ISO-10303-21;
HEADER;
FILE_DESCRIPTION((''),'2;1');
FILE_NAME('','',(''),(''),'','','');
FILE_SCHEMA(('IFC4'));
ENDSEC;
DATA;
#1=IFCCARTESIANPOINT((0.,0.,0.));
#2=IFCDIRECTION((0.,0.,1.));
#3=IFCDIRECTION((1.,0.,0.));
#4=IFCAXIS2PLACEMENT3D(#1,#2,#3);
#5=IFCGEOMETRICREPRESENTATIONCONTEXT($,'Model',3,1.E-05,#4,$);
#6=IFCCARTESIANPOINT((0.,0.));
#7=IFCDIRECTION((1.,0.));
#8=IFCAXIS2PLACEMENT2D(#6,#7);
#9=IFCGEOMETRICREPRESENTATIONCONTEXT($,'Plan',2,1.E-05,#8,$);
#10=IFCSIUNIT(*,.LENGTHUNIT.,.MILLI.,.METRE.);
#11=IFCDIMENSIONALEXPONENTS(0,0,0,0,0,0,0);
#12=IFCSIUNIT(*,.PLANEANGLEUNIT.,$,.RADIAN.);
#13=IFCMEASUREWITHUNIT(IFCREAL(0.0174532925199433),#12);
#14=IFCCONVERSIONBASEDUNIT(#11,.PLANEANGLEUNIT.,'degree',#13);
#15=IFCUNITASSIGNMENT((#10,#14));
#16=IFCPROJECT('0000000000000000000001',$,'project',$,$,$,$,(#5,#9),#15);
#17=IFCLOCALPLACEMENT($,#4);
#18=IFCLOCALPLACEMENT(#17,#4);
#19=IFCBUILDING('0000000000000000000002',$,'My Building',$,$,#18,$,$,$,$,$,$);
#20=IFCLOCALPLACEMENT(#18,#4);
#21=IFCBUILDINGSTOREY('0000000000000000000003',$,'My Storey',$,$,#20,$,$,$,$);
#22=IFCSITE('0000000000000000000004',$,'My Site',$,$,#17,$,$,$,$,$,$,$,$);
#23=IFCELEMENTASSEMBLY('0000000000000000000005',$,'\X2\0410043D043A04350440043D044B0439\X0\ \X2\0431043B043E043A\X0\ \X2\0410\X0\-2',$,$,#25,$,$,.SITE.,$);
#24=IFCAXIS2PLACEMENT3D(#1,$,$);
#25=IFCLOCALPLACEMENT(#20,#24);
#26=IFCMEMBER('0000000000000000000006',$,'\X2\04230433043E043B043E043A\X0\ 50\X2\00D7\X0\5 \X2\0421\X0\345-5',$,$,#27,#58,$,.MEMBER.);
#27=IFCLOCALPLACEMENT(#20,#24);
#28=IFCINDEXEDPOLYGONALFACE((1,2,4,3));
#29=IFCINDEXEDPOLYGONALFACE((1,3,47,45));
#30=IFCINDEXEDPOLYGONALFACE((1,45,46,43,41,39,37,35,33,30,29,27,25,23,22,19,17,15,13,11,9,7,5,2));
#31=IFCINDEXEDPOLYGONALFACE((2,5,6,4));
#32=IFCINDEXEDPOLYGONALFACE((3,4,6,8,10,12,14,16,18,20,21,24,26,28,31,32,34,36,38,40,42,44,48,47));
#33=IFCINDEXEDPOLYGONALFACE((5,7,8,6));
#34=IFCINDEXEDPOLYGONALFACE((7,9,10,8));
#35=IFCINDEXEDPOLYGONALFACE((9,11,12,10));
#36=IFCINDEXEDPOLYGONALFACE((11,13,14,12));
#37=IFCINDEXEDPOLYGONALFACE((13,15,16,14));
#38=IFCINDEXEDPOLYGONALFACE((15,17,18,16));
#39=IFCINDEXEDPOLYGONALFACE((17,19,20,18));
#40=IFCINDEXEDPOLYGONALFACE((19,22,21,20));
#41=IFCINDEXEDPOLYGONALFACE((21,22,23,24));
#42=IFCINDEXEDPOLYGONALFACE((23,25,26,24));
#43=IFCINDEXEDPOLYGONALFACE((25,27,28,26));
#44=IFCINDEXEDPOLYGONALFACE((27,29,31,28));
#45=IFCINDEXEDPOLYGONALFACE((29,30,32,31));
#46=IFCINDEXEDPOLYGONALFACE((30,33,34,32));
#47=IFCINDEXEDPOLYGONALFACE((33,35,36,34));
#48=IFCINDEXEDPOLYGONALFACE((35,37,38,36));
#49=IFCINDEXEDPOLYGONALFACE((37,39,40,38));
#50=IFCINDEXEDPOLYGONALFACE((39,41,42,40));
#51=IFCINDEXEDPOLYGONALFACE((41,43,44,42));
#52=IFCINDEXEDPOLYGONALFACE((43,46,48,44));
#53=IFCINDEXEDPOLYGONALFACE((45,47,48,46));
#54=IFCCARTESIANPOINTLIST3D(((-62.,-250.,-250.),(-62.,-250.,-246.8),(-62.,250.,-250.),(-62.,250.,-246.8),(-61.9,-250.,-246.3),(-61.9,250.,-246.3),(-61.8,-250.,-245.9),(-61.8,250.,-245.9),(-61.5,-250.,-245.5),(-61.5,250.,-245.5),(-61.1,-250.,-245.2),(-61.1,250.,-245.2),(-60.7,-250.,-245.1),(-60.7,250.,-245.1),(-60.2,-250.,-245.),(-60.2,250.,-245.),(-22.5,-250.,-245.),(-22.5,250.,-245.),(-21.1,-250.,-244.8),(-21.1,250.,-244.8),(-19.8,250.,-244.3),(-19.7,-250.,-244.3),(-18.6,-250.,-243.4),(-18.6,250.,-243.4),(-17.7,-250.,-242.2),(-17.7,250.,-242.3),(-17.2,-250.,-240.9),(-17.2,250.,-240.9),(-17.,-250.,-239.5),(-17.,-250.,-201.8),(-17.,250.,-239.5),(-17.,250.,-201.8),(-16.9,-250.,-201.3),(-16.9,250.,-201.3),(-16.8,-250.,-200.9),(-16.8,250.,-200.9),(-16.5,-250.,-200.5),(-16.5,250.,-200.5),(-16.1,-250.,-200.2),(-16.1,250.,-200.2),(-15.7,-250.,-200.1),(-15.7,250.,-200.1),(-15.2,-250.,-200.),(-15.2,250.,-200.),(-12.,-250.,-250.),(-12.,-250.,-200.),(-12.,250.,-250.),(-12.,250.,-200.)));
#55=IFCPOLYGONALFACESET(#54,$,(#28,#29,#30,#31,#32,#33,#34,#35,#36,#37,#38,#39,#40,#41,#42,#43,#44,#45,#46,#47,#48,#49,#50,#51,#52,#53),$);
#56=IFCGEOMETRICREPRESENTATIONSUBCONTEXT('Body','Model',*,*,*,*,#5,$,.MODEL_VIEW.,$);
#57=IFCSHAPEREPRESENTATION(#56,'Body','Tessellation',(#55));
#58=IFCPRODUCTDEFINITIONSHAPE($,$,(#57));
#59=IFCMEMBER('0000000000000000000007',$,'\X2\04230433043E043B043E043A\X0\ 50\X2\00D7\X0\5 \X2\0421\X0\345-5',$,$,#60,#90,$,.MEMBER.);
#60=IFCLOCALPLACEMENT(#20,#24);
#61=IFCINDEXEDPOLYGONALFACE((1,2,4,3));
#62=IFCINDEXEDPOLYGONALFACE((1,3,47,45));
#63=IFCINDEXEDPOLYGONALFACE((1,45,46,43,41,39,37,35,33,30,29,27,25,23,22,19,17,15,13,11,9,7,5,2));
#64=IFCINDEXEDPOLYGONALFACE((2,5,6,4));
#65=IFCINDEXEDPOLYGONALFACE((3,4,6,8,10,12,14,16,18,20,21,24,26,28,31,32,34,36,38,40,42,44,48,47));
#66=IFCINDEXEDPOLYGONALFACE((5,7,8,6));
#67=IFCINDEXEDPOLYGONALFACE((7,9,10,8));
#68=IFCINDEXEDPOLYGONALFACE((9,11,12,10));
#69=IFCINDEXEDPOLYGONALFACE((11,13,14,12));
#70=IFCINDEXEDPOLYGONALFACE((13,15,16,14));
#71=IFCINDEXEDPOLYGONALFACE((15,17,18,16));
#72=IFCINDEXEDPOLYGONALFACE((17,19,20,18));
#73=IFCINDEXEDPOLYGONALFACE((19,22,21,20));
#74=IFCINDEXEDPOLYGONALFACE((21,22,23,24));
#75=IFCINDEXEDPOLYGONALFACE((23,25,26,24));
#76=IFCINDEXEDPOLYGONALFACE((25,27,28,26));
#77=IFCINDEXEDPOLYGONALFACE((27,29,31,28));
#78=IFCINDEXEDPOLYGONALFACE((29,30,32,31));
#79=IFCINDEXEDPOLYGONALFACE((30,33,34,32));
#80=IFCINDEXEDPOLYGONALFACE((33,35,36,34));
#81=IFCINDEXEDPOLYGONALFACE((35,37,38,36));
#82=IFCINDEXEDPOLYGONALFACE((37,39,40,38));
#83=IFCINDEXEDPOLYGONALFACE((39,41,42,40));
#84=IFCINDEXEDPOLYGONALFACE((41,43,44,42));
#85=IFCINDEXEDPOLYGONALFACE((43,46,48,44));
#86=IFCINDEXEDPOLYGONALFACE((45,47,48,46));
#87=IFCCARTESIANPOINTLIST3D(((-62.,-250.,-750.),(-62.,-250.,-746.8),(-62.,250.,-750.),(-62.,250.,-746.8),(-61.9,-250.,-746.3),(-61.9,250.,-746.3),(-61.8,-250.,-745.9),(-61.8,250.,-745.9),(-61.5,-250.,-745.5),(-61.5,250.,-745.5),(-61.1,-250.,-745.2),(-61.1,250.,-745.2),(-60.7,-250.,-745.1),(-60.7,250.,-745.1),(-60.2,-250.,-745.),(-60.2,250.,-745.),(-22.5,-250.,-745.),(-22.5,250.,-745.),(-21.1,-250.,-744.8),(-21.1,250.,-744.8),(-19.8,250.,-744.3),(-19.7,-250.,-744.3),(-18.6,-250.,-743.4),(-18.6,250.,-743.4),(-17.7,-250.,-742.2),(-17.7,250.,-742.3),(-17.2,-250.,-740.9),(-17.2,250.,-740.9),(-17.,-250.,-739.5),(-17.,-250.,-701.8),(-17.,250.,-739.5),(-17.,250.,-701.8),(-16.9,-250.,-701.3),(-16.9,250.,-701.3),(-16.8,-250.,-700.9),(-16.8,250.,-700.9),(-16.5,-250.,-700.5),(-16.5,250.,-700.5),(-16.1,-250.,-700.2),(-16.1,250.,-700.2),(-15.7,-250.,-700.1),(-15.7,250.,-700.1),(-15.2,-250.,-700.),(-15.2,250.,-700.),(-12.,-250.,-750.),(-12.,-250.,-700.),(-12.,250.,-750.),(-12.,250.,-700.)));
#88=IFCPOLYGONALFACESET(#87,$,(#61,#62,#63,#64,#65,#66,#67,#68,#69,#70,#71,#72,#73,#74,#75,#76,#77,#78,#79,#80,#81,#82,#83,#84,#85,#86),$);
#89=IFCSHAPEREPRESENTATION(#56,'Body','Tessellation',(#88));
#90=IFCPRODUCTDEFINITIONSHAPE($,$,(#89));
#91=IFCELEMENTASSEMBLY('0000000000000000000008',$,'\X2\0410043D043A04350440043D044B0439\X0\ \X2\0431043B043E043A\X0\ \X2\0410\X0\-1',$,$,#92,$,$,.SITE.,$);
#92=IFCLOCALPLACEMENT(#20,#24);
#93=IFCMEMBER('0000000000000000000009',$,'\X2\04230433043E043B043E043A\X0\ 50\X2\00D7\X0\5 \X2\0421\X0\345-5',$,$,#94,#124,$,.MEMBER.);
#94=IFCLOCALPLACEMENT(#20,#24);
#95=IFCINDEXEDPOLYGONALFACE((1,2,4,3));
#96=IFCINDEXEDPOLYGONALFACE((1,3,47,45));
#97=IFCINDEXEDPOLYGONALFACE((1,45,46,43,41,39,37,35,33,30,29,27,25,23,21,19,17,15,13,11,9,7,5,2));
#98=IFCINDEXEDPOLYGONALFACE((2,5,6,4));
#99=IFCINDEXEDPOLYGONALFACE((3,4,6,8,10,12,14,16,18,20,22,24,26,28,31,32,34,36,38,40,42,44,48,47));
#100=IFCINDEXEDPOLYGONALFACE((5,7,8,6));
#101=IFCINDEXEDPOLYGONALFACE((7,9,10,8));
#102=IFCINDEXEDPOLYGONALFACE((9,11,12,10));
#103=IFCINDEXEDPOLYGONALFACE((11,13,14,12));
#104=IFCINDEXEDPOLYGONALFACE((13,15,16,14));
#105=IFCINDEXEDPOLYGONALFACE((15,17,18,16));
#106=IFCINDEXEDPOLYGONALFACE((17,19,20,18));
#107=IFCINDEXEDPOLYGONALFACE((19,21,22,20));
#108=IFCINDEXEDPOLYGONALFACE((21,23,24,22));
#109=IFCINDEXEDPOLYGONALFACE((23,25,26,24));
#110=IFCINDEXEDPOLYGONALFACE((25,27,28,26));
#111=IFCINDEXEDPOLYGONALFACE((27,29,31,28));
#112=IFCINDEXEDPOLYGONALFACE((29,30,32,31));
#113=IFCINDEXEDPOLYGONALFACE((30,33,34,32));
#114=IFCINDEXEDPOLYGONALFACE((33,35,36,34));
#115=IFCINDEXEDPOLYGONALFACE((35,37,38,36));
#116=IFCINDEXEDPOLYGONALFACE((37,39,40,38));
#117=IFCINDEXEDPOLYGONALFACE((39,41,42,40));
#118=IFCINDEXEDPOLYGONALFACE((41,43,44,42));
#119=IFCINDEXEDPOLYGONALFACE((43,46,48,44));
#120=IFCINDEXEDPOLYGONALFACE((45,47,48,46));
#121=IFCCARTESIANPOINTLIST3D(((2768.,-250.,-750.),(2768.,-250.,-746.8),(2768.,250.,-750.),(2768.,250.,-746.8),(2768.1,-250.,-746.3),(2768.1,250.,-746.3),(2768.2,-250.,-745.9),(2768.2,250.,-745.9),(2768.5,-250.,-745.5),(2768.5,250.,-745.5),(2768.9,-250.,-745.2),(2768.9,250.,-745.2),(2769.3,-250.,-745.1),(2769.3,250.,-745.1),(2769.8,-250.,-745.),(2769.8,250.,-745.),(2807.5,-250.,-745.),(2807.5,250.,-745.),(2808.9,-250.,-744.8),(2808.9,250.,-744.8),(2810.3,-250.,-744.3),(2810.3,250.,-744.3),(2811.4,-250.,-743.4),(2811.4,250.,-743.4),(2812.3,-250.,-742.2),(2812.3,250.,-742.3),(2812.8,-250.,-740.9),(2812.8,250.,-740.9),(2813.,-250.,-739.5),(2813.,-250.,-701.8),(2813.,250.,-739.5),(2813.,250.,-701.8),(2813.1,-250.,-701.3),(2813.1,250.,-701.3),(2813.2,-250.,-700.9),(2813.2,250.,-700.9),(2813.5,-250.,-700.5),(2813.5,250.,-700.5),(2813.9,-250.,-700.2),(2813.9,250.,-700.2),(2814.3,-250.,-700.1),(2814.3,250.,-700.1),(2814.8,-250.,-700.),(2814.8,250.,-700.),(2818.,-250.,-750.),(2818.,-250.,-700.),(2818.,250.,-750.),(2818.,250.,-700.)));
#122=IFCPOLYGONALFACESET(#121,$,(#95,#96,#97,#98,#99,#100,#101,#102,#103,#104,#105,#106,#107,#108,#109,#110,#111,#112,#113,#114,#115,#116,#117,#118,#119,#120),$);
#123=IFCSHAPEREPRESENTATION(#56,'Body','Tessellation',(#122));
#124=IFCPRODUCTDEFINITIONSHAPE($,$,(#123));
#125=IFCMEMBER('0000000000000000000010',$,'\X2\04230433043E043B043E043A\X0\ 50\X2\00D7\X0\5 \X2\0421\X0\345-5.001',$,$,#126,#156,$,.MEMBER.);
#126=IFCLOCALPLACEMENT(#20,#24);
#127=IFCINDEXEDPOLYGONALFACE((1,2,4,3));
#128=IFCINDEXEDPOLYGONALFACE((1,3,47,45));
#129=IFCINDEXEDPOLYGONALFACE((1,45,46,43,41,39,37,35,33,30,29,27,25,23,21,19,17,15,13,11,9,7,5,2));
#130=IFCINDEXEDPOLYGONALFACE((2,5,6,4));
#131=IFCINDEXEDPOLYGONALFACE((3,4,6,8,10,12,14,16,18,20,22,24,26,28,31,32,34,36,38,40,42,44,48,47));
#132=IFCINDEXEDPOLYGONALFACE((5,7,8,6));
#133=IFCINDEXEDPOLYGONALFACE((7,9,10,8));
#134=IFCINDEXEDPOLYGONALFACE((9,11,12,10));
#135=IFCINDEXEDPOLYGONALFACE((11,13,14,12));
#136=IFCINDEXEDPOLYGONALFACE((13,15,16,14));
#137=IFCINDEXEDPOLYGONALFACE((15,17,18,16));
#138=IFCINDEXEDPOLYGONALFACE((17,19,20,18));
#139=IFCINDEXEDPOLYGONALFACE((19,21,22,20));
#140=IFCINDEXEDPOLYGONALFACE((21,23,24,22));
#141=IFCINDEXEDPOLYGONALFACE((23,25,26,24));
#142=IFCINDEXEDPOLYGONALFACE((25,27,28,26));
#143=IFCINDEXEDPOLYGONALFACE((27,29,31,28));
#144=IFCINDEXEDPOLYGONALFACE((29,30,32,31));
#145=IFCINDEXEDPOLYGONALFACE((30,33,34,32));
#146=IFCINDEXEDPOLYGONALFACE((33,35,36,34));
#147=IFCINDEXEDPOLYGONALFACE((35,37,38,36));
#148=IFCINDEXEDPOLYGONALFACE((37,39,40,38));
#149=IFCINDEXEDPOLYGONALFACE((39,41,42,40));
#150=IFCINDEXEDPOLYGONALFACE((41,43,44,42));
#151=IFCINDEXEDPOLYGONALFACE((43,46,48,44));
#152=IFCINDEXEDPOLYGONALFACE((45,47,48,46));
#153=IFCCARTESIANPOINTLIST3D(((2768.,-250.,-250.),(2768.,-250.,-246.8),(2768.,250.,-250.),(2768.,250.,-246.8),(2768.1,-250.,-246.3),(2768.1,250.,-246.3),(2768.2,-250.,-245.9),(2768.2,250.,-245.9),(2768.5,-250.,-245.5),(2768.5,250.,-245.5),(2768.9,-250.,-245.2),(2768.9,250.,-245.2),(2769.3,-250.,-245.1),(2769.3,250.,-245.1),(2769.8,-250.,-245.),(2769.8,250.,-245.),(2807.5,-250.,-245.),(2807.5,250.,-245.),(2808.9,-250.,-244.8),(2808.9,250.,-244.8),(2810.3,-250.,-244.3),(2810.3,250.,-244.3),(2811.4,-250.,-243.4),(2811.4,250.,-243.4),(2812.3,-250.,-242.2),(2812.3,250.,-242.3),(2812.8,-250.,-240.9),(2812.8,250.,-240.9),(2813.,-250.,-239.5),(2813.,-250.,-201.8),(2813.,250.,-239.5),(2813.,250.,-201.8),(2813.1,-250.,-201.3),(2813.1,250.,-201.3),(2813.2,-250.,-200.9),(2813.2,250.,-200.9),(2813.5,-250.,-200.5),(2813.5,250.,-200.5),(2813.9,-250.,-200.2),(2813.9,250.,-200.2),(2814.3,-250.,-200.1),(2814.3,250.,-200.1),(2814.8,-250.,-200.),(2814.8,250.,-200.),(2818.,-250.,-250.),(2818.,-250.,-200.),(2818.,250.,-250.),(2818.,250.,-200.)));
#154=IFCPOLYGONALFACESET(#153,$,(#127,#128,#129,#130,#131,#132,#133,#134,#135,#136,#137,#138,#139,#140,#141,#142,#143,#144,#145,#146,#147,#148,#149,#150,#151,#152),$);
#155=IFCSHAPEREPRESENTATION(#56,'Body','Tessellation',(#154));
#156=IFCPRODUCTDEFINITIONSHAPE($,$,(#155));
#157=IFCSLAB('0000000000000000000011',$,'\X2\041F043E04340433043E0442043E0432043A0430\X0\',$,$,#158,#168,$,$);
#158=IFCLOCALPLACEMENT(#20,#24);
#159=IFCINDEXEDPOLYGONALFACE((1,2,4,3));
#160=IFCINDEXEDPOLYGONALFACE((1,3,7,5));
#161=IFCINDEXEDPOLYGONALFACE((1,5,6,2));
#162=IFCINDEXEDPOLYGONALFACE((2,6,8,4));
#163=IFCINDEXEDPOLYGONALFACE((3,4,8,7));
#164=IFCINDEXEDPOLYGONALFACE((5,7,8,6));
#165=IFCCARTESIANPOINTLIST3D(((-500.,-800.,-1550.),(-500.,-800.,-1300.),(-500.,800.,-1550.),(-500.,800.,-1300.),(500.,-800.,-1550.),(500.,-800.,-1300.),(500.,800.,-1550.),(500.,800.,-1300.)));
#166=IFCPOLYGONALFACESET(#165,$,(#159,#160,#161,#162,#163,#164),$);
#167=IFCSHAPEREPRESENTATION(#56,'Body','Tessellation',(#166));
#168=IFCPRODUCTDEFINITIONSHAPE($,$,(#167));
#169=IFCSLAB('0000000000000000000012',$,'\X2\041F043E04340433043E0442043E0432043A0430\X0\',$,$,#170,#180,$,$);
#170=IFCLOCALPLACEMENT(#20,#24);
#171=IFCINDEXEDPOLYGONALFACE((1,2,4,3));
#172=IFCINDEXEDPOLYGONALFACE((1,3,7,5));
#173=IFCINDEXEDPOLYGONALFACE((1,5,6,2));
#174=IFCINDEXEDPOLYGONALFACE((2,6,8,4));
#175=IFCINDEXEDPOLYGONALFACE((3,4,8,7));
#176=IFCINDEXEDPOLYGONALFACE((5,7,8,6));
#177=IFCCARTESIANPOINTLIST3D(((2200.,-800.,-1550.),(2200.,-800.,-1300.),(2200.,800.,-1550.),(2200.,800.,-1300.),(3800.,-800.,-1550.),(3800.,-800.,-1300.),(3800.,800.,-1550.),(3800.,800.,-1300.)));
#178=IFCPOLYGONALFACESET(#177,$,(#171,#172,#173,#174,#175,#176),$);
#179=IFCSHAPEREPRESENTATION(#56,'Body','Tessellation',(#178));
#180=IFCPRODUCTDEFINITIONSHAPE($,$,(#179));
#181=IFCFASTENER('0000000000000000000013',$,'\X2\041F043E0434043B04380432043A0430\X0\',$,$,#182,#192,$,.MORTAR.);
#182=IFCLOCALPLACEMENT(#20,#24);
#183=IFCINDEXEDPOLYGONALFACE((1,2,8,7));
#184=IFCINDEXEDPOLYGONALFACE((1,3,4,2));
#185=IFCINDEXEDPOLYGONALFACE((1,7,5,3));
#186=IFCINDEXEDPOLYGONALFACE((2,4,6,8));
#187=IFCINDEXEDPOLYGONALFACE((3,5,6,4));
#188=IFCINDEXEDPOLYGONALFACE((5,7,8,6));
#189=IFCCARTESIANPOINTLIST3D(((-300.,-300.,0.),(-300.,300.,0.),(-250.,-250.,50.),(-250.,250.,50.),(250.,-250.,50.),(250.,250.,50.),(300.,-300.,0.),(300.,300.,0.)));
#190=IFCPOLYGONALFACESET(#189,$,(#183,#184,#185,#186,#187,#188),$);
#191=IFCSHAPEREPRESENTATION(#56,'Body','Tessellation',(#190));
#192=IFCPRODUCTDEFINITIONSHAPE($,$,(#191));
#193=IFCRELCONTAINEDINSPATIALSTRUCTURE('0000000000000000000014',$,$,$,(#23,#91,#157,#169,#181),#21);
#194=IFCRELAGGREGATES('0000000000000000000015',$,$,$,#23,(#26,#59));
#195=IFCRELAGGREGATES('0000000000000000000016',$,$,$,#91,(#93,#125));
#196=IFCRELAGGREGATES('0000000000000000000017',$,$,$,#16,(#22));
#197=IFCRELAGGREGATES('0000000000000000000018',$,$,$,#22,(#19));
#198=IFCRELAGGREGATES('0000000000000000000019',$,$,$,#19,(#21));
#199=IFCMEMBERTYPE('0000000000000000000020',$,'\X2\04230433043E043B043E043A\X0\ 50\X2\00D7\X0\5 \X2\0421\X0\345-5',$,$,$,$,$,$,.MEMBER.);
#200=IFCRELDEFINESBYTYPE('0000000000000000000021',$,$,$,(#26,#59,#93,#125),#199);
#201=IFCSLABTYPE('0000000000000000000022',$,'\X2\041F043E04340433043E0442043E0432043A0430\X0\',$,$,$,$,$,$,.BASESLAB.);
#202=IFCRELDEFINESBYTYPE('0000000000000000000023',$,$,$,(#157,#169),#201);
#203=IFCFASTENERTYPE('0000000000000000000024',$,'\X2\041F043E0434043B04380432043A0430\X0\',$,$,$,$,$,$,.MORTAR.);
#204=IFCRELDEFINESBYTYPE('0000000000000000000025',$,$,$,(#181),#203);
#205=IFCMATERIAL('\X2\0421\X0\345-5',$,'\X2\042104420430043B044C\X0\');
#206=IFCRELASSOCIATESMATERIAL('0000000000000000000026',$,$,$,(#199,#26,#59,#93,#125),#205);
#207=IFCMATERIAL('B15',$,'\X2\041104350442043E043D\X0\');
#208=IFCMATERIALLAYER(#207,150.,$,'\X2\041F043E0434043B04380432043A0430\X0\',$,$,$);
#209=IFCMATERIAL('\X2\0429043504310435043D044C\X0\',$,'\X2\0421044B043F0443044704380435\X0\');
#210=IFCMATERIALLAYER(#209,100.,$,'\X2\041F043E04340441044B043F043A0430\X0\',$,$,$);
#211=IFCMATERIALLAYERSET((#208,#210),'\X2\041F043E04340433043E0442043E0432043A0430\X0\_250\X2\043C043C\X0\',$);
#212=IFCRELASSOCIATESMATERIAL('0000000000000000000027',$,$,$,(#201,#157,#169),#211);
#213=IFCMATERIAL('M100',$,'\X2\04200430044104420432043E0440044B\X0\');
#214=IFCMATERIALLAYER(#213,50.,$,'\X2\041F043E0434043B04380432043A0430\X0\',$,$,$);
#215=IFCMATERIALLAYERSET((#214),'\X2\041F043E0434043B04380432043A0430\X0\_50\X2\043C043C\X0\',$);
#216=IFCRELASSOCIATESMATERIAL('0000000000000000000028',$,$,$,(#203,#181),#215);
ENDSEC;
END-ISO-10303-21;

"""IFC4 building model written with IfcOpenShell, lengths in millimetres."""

from ifc_helpers import new_model, entity, si_unit, converted_unit, frame, origin_with_axes, origin_2d_with_axis, place, context, subcontext, project, spatial, line, indexed_curve, l_section, outline, extrude, clip, halfspace, material, layer, layer_set, layer_usage, material_profile, profile_set, profile_usage, type_object, element, aggregate, save


model = new_model("IFC4")

# Units and contexts
model_context = context("Model", 3, precision=1e-05, world=origin_with_axes())
plan_context = context("Plan", 2, precision=1e-05, world=origin_2d_with_axis())
body_context = subcontext(model_context, "Body", "Model", "MODEL_VIEW")
ifc_project = project(units=[si_unit("LENGTHUNIT", "METRE", prefix="MILLI"), converted_unit("PLANEANGLEUNIT", "degree", entity("IfcReal", 0.0174532925199433), si_unit("PLANEANGLEUNIT", "RADIAN"), dimensions=[0, 0, 0, 0, 0, 0, 0])], contexts=[model_context, plan_context])

# Site, building, storey
site_placement = place(None, origin_with_axes())
site = spatial("IfcSite", under=ifc_project, at=site_placement, Name="My Site")
building_placement = place(site_placement, origin_with_axes())
building = spatial("IfcBuilding", under=site, at=building_placement, Name="My Building")
storey_placement = place(building_placement, origin_with_axes())
storey = spatial("IfcBuildingStorey", under=building, at=storey_placement, Name="My Storey")

# Element assemblies, members
placement_1 = place(storey_placement, origin_with_axes())
assembly_1 = element("IfcElementAssembly", 1, at=placement_1, inside=storey, Name="Анкерный блок А-2", AssemblyPlace="SITE")
ifc_material_1 = material(Name="С345-5", Category="Сталь")
ifc_material_profile = material_profile(ifc_material_1, l_section(Depth=50.0, Width=50.0, Thickness=5.0, FilletRadius=5.5, EdgeRadius=1.8))
ifc_profile_set = profile_set([ifc_material_profile])
ifc_profile_usage_1 = profile_usage(ifc_profile_set, cardinal=3)
member_type = type_object("IfcMemberType", Name="Уголок 50×5 С345-5", PredefinedType="MEMBER", material=ifc_profile_set)
member_1_placement = place(placement_1, frame((-12.0, -250.0, -250.0), z_axis=(0.0, 1.0, 0.0), x_axis=(-1.0, 0.0, 0.0)))
member_1 = element("IfcMember", 2, at=member_1_placement, type_object=member_type, material=ifc_profile_usage_1, Name="Уголок 50×5 С345-5", PredefinedType="MEMBER", context=body_context, shape_type="SweptSolid", body=[
    extrude(l_section(Depth=50.0, Width=50.0, Thickness=5.0, FilletRadius=5.5, EdgeRadius=1.8), frame((25.0, 25.0, 0.0), z_axis=(0.0, 0.0, 1.0), x_axis=(1.0, 0.0, 0.0)), (0.0, 0.0, 1.0), 500.0),
])
ifc_profile_usage_2 = profile_usage(ifc_profile_set, cardinal=3)
member_2_placement = place(placement_1, frame((-12.0, -250.0, -750.0), z_axis=(0.0, 1.0, 0.0), x_axis=(-1.0, 0.0, 0.0)))
member_2 = element("IfcMember", 3, at=member_2_placement, type_object=member_type, material=ifc_profile_usage_2, Name="Уголок 50×5 С345-5", PredefinedType="MEMBER", context=body_context, shape_type="SweptSolid", body=[
    extrude(l_section(Depth=50.0, Width=50.0, Thickness=5.0, FilletRadius=5.5, EdgeRadius=1.8), frame((25.0, 25.0, 0.0), z_axis=(0.0, 0.0, 1.0), x_axis=(1.0, 0.0, 0.0)), (0.0, 0.0, 1.0), 500.0),
])
placement_2 = place(storey_placement, frame((3000.0, 0.0, 0.0), z_axis=(0.0, 0.0, 1.0), x_axis=(1.0, 0.0, 0.0)))
assembly_2 = element("IfcElementAssembly", 4, at=placement_2, inside=storey, Name="Анкерный блок А-1", AssemblyPlace="SITE")
ifc_profile_usage_3 = profile_usage(ifc_profile_set, cardinal=3)
member_3_placement = place(placement_2, frame((-182.0, -250.0, -750.0), z_axis=(0.0, 1.0, 0.0), x_axis=(-1.0, 0.0, 0.0)))
member_3 = element("IfcMember", 5, at=member_3_placement, type_object=member_type, material=ifc_profile_usage_3, Name="Уголок 50×5 С345-5", PredefinedType="MEMBER", context=body_context, shape_type="SweptSolid", body=[
    extrude(l_section(Depth=50.0, Width=50.0, Thickness=5.0, FilletRadius=5.5, EdgeRadius=1.8), frame((25.0, 25.0, 0.0), z_axis=(0.0, 0.0, 1.0), x_axis=(1.0, 0.0, 0.0)), (0.0, 0.0, 1.0), 500.0),
])
ifc_profile_usage_4 = profile_usage(ifc_profile_set, cardinal=3)
member_4_placement = place(placement_2, frame((-182.0, -250.0, -250.0), z_axis=(0.0, 1.0, 0.0), x_axis=(-1.0, 0.0, 0.0)))
member_4 = element("IfcMember", 6, at=member_4_placement, type_object=member_type, material=ifc_profile_usage_4, Name="Уголок 50×5 С345-5.001", PredefinedType="MEMBER", context=body_context, shape_type="SweptSolid", body=[
    extrude(l_section(Depth=50.0, Width=50.0, Thickness=5.0, FilletRadius=5.5, EdgeRadius=1.8), frame((25.0, 25.0, 0.0), z_axis=(0.0, 0.0, 1.0), x_axis=(1.0, 0.0, 0.0)), (0.0, 0.0, 1.0), 500.0),
])

# Slabs
ifc_material_2 = material(Name="B15", Category="Бетон")
ifc_layer_1 = layer(ifc_material_2, 150.0, Name="Подливка")
ifc_material_3 = material(Name="Щебень", Category="Сыпучие")
ifc_layer_2 = layer(ifc_material_3, 100.0, Name="Подсыпка")
ifc_layer_set_1 = layer_set([ifc_layer_1, ifc_layer_2], Name="Подготовка_250мм")
ifc_layer_usage_1 = layer_usage(ifc_layer_set_1, "AXIS3", "NEGATIVE", 0.0)
slab_type = type_object("IfcSlabType", Name="Подготовка", PredefinedType="BASESLAB", material=ifc_layer_set_1)
slab_1_placement = place(storey_placement, frame((0.0, 0.0, -1550.0), z_axis=(0.0, 0.0, 1.0), x_axis=(1.0, 0.0, 0.0)))
element("IfcSlab", 7, at=slab_1_placement, inside=storey, type_object=slab_type, material=ifc_layer_usage_1, Name="Подготовка", context=body_context, shape_type="SweptSolid", body=[
    extrude(outline(indexed_curve([(-500.0, -800.0), (500.0, -800.0), (500.0, 800.0), (-500.0, 800.0)], segments=[line(3, 2), line(2, 1), line(1, 4), line(4, 3)], self_intersect=False)), None, (0.0, 0.0, 1.0), 250.0),
])
slab_2_placement = place(storey_placement, frame((3000.0, 0.0, -1550.0), z_axis=(0.0, 0.0, 1.0), x_axis=(1.0, 0.0, 0.0)))
element("IfcSlab", 8, at=slab_2_placement, inside=storey, type_object=slab_type, material=ifc_layer_usage_1, Name="Подготовка", context=body_context, shape_type="SweptSolid", body=[
    extrude(outline(indexed_curve([(-800.0, -800.0), (800.0, -800.0), (800.0, 800.0), (-800.0, 800.0)], segments=[line(3, 2), line(2, 1), line(1, 4), line(4, 3)], self_intersect=False)), None, (0.0, 0.0, 1.0), 250.0),
])

# Fastener
ifc_material_4 = material(Name="M100", Category="Растворы")
ifc_layer_3 = layer(ifc_material_4, 50.0, Name="Подливка")
ifc_layer_set_2 = layer_set([ifc_layer_3], Name="Подливка_50мм")
ifc_layer_usage_2 = layer_usage(ifc_layer_set_2, "AXIS3", "POSITIVE", 0.0)
fastener_type = type_object("IfcFastenerType", Name="Подливка", PredefinedType="MORTAR", material=ifc_layer_set_2)
element("IfcFastener", 9, at=placement_1, inside=storey, type_object=fastener_type, material=ifc_layer_usage_2, Name="Подливка", PredefinedType="MORTAR", context=body_context, shape_type="Clipping", body=[
    clip(clip(clip(clip(extrude(outline(indexed_curve([(-300.0, -300.0), (300.0, -300.0), (300.0, 300.0), (-300.0, 300.0)], segments=[line(3, 2), line(2, 1), line(1, 4), line(4, 3)], self_intersect=False)), None, (0.0, 0.0, 1.0), 50.0), halfspace(frame((-53.6, 200.0, 353.6), z_axis=(0.707107, 0.0, 0.707107), x_axis=(0.707107, 0.0, -0.707107)), False)), halfspace(frame((-200.0, -53.6, 353.6), z_axis=(0.0, 0.707107, 0.707107), x_axis=(0.0, 0.707107, -0.707107)), False)), halfspace(frame((200.0, 53.6, 353.6), z_axis=(0.0, -0.707107, 0.707107), x_axis=(0.0, -0.707107, -0.707107)), False)), halfspace(frame((53.6, 200.0, 353.6), z_axis=(-0.707107, 0.0, 0.707107), x_axis=(-0.707107, 0.0, -0.707107)), False)),
])

aggregate(assembly_1, [member_1, member_2])

aggregate(assembly_2, [member_3, member_4])

save(model, "model.ifc")
